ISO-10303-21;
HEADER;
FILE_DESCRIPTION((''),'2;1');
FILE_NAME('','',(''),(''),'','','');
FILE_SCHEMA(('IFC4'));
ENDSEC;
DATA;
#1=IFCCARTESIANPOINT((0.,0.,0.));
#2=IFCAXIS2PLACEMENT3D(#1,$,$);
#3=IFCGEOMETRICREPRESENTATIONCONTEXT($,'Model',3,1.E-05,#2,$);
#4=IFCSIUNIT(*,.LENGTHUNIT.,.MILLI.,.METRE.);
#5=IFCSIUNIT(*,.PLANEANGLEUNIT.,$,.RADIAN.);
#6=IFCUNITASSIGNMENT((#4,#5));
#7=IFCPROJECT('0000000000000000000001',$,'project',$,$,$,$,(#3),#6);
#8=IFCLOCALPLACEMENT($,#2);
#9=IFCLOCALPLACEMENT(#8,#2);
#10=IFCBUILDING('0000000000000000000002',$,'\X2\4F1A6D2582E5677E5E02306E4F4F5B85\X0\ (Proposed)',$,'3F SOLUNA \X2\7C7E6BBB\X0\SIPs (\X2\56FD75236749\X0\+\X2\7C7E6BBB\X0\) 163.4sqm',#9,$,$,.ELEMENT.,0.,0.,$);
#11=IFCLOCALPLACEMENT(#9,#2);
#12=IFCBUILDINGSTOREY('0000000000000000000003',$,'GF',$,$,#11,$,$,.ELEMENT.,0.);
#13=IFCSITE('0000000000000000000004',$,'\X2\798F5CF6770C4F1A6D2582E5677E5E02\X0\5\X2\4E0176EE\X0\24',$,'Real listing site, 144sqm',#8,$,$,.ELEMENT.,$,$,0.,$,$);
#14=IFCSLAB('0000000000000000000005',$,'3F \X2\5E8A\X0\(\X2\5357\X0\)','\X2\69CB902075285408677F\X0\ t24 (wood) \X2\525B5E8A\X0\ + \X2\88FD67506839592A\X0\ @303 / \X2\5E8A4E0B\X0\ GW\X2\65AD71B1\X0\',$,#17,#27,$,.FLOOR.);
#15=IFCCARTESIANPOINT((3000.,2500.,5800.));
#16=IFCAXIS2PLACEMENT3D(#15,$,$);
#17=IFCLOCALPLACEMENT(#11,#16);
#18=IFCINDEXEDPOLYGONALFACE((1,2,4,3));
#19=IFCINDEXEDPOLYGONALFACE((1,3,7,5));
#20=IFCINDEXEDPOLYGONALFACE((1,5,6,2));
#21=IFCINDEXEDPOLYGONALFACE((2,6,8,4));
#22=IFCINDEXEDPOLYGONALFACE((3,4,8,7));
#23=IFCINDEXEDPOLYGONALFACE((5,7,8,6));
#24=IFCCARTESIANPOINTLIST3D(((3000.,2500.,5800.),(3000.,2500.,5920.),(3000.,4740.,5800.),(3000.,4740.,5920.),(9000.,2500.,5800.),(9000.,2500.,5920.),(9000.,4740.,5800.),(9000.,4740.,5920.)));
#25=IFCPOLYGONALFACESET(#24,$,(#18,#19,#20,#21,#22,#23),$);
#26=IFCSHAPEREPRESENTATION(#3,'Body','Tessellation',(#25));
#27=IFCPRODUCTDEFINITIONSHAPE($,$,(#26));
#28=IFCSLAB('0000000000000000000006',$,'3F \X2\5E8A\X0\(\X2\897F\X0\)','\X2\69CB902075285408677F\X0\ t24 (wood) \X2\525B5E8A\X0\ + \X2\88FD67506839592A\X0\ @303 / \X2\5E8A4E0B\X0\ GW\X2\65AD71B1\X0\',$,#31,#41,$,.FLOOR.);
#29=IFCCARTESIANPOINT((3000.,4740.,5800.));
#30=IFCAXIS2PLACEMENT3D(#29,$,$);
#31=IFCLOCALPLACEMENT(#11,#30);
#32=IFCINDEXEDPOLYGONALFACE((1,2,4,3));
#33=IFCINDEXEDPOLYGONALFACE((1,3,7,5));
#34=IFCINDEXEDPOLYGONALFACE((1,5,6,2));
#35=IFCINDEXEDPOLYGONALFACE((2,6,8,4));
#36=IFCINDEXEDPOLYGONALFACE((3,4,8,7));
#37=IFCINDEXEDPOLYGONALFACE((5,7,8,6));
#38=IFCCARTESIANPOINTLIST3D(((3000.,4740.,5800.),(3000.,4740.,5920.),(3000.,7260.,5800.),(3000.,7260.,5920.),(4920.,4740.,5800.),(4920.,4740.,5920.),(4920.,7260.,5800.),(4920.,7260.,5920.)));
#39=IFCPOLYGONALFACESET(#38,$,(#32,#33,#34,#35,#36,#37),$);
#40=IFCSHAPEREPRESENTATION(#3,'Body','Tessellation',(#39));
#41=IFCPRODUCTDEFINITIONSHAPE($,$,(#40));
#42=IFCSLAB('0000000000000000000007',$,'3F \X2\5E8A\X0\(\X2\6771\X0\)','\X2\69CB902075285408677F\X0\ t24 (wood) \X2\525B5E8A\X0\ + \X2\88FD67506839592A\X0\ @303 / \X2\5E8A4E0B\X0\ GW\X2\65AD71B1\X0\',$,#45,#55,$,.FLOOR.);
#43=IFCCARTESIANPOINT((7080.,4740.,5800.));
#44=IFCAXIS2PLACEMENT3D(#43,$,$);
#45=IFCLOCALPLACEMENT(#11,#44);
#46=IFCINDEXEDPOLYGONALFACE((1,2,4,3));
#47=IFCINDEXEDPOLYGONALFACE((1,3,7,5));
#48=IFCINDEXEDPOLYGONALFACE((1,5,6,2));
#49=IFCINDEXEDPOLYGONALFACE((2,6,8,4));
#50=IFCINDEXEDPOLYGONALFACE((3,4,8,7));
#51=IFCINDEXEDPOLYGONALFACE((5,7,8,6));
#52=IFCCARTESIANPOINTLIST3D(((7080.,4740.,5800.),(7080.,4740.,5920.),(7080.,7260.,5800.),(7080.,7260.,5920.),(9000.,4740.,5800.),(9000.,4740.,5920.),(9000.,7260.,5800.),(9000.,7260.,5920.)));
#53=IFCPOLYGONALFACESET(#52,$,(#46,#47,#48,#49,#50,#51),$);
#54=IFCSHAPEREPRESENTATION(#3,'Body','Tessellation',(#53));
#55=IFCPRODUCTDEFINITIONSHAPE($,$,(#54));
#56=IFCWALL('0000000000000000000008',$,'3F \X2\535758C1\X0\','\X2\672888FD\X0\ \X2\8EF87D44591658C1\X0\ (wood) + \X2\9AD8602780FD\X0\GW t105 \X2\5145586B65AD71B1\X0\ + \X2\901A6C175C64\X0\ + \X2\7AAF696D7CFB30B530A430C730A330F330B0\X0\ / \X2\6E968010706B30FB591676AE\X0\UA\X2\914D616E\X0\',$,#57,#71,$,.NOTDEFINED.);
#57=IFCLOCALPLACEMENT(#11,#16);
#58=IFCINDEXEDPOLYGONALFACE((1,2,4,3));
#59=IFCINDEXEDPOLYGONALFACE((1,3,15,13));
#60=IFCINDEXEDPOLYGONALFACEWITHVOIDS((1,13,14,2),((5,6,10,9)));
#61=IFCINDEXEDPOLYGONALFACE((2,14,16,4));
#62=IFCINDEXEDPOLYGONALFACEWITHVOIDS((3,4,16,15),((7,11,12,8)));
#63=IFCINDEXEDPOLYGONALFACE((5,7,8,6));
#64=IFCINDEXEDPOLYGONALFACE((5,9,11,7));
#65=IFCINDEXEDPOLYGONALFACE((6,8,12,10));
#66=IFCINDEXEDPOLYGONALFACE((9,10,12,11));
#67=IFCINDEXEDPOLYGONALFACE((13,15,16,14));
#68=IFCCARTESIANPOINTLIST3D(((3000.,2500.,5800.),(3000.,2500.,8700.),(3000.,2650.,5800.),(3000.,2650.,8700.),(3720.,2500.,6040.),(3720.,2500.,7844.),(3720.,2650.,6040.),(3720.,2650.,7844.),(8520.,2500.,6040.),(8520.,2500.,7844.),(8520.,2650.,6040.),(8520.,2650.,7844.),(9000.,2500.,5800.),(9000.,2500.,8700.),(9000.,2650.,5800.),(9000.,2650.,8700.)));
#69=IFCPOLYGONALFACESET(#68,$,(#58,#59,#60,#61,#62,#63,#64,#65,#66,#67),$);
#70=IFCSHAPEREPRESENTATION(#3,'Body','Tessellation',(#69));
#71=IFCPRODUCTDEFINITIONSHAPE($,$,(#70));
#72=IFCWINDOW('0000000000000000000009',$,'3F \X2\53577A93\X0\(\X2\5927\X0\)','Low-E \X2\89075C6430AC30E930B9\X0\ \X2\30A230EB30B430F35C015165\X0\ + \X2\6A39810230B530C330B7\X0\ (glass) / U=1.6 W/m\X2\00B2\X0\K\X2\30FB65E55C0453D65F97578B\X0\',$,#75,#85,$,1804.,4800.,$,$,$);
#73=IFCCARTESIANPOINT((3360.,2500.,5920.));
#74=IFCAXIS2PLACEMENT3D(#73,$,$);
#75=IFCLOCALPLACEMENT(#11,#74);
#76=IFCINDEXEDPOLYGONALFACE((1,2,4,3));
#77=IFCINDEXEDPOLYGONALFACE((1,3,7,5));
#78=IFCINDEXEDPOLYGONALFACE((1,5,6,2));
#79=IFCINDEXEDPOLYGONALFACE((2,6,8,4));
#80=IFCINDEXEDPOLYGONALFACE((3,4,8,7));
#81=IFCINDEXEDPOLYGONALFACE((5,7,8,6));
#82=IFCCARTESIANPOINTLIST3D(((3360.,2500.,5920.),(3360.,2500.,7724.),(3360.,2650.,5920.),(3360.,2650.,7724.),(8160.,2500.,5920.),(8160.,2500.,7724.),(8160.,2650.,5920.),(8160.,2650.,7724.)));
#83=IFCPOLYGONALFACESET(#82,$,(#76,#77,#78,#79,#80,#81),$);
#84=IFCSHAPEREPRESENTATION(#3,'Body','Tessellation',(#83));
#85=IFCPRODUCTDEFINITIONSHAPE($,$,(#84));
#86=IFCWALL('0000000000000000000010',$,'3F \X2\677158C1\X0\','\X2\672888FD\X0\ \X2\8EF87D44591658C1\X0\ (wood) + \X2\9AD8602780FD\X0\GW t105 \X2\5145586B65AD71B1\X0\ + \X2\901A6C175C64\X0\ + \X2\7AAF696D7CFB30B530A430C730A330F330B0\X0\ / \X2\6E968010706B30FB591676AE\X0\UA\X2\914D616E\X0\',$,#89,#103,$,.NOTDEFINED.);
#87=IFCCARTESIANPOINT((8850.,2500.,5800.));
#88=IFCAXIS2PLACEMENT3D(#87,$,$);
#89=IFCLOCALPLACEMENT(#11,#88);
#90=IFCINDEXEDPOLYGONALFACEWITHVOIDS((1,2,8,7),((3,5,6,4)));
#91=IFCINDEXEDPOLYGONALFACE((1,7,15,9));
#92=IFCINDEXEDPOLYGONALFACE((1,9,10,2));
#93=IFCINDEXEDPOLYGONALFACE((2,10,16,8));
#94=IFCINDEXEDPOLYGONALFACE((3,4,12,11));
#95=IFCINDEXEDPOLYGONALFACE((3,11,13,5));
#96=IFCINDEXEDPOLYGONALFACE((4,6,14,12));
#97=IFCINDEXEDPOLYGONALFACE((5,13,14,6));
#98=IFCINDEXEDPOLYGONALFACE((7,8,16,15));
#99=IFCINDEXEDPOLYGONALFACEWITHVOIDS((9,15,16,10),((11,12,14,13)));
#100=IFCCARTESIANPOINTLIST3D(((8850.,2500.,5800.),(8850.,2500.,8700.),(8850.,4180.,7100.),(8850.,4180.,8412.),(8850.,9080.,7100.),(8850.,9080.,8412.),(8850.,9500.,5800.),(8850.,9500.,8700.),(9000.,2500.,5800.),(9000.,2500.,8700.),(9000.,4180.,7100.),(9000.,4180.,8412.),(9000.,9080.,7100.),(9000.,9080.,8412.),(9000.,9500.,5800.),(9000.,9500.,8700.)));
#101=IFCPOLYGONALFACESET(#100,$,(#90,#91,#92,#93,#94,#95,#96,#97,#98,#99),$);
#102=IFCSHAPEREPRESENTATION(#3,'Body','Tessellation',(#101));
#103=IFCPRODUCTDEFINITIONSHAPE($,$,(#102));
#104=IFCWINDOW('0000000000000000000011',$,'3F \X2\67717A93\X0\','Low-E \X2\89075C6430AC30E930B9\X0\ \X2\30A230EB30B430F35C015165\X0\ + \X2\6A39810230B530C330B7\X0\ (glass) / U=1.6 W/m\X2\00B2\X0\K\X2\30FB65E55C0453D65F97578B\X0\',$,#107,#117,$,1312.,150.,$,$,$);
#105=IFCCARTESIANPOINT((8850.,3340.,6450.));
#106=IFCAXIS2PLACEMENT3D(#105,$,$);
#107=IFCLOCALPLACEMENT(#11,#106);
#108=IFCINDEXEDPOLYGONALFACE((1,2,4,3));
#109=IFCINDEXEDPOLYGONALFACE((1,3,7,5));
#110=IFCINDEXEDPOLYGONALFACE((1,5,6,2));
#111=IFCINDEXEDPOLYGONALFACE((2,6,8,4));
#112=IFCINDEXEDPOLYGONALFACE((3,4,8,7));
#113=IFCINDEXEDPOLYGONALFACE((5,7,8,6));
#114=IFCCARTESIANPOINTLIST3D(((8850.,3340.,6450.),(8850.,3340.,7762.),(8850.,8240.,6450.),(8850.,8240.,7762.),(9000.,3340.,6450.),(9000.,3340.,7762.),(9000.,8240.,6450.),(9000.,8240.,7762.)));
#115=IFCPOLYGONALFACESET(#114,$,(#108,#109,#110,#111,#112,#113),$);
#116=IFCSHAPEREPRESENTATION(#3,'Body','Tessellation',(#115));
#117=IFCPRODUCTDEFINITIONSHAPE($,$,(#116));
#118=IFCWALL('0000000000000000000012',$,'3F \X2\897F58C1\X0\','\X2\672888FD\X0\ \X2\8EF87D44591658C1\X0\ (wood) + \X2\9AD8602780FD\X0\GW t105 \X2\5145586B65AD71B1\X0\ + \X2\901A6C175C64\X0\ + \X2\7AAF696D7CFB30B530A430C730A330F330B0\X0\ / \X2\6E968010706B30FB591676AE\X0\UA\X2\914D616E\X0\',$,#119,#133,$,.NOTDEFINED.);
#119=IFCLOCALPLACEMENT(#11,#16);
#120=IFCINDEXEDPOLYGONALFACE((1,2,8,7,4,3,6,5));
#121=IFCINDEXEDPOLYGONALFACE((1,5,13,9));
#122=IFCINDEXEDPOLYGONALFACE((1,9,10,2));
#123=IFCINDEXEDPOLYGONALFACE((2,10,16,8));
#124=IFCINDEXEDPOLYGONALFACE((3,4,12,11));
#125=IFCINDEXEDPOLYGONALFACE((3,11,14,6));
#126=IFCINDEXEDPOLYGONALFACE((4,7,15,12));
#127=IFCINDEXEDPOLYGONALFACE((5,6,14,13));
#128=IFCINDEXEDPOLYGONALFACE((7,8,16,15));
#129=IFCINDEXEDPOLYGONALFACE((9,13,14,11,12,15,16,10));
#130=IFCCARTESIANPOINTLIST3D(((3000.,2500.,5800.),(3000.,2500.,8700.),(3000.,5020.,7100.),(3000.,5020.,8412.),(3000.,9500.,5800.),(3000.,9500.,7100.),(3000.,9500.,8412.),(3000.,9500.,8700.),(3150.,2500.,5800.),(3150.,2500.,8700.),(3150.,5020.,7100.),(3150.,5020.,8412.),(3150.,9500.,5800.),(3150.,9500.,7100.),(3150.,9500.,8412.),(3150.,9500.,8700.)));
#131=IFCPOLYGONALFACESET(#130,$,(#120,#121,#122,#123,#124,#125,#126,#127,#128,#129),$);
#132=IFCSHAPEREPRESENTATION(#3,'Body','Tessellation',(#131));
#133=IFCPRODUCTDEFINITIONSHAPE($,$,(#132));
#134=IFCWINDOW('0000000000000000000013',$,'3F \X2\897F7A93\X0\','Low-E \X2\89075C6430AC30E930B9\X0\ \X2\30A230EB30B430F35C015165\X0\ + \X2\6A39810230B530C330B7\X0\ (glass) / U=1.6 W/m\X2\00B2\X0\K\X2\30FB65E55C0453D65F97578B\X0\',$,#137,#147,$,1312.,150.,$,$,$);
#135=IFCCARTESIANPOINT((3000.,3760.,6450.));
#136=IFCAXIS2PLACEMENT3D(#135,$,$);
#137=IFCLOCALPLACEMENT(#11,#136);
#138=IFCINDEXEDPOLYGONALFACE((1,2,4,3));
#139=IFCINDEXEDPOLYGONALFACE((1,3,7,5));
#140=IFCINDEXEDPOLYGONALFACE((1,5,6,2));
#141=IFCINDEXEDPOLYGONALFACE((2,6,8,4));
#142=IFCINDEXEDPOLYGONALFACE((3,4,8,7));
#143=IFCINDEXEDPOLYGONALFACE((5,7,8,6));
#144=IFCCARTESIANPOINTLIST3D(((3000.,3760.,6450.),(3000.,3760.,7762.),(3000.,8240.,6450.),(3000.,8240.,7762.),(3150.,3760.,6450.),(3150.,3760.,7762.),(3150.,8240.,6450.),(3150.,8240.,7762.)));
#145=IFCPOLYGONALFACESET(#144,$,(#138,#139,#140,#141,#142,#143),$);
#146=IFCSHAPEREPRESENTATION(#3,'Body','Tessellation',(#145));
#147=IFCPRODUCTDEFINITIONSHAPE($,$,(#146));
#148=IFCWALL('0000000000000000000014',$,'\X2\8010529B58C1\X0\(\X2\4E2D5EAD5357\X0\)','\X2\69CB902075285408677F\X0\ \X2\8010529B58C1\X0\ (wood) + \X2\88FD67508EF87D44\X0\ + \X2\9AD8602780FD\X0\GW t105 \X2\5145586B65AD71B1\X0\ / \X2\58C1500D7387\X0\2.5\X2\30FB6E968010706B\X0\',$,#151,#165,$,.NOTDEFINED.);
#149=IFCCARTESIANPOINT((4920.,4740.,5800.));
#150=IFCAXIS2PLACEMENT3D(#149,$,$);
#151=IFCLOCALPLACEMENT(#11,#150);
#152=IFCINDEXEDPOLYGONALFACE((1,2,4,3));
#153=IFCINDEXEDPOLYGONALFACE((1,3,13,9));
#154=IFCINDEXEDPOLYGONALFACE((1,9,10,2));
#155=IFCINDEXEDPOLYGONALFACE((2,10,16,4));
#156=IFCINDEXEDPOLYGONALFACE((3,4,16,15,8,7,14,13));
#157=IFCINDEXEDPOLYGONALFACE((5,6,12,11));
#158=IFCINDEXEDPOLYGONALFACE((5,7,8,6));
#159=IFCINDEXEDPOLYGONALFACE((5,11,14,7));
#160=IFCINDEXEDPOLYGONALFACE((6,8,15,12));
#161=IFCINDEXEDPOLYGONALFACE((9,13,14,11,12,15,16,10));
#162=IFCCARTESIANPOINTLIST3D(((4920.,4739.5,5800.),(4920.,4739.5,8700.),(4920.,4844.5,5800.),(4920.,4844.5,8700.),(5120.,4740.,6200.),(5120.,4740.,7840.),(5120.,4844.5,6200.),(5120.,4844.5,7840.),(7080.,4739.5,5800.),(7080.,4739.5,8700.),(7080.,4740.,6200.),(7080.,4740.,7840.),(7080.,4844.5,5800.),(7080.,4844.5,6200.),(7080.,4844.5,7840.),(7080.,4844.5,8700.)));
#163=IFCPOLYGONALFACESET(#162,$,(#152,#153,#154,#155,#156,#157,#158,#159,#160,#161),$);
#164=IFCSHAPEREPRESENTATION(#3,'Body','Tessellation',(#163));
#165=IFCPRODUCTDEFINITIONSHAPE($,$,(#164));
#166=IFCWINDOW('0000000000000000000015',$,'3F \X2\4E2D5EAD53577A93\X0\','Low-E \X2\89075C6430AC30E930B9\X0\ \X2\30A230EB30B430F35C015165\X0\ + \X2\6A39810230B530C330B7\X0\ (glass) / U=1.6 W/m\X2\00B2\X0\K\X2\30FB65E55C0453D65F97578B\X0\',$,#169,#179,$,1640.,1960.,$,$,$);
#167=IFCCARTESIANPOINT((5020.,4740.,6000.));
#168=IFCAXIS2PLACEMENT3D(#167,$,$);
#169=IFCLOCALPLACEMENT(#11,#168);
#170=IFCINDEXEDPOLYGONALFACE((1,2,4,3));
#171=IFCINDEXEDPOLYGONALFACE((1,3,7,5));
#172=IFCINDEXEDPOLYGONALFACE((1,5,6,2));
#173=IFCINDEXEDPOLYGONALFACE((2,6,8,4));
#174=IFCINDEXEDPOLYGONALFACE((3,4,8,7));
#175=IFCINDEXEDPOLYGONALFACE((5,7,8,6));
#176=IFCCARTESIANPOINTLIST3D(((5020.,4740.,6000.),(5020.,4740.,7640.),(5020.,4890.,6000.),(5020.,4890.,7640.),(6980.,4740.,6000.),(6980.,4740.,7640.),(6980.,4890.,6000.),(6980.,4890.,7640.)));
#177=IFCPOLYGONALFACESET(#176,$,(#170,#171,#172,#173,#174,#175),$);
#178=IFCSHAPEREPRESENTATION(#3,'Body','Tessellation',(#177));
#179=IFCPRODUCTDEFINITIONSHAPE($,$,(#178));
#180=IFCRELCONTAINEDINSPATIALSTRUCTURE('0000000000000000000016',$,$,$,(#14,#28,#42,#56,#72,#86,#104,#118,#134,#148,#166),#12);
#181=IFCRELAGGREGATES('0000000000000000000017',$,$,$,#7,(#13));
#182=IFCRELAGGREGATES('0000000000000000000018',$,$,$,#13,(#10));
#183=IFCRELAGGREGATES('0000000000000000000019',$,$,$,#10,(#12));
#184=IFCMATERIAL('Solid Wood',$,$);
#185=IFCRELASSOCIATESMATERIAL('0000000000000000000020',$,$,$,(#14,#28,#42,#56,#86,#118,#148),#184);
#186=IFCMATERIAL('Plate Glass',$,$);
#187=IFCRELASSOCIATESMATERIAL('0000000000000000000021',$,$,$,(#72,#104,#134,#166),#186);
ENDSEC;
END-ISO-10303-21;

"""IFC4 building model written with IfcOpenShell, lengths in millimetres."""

from ifc_helpers import new_model, si_unit, frame, frame_2d, origin, place, context, project, spatial, rectangle, extrude, material, element, fill, save


model = new_model("IFC4")

# Units and contexts
model_context = context("Model", 3, precision=1e-05, world=origin())
ifc_project = project(units=[si_unit("LENGTHUNIT", "METRE", prefix="MILLI"), si_unit("PLANEANGLEUNIT", "RADIAN")], contexts=[model_context])

# Site, building, storey
site_placement = place(None, origin())
site = spatial("IfcSite", under=ifc_project, at=site_placement, Name="福島県会津若松市5丁目24", ObjectType="Real listing site, 144sqm", CompositionType="ELEMENT", RefElevation=0.0)
building_placement = place(site_placement, origin())
building = spatial("IfcBuilding", under=site, at=building_placement, Name="会津若松市の住宅 (Proposed)", ObjectType="3F SOLUNA 籾殻SIPs (国産杉+籾殻) 163.4sqm", CompositionType="ELEMENT", ElevationOfRefHeight=0.0, ElevationOfTerrain=0.0)
storey_placement = place(building_placement, origin())
storey = spatial("IfcBuildingStorey", under=building, at=storey_placement, Name="GF", CompositionType="ELEMENT", Elevation=0.0)

# Slabs
ifc_material_1 = material(Name="Solid Wood")
slab_1_placement = place(storey_placement, frame((3000.0, 2500.0, 5800.0)))
element("IfcSlab", 1, at=slab_1_placement, inside=storey, material=ifc_material_1, Name="3F 床(南)", Description="構造用合板 t24 (wood) 剛床 + 製材根太 @303 / 床下 GW断熱", PredefinedType="FLOOR", context=model_context, shape_type="SweptSolid", body=[
    extrude(rectangle(XDim=6000.0, YDim=2240.0, at=frame_2d((3000.0, 1120.0))), frame((3000.0, 2500.0, 5800.0)), (0.0, 0.0, 1.0), 120.0),
])
slab_2_placement = place(storey_placement, frame((3000.0, 4740.0, 5800.0)))
element("IfcSlab", 2, at=slab_2_placement, inside=storey, material=ifc_material_1, Name="3F 床(西)", Description="構造用合板 t24 (wood) 剛床 + 製材根太 @303 / 床下 GW断熱", PredefinedType="FLOOR", context=model_context, shape_type="SweptSolid", body=[
    extrude(rectangle(XDim=1920.0, YDim=2520.0, at=frame_2d((960.0, 1260.0))), frame((3000.0, 4740.0, 5800.0)), (0.0, 0.0, 1.0), 120.0),
])
slab_3_placement = place(storey_placement, frame((7080.0, 4740.0, 5800.0)))
element("IfcSlab", 3, at=slab_3_placement, inside=storey, material=ifc_material_1, Name="3F 床(東)", Description="構造用合板 t24 (wood) 剛床 + 製材根太 @303 / 床下 GW断熱", PredefinedType="FLOOR", context=model_context, shape_type="SweptSolid", body=[
    extrude(rectangle(XDim=1920.0, YDim=2520.0, at=frame_2d((960.0, 1260.0))), frame((7080.0, 4740.0, 5800.0)), (0.0, 0.0, 1.0), 120.0),
])

# Walls, openings, windows
wall_1_placement = place(storey_placement, frame((3000.0, 2500.0, 5800.0)))
wall_1 = element("IfcWall", 4, at=wall_1_placement, inside=storey, material=ifc_material_1, Name="3F 南壁", Description="木製 軸組外壁 (wood) + 高性能GW t105 充填断熱 + 通気層 + 窯業系サイディング / 準耐火・外皮UA配慮", PredefinedType="NOTDEFINED", context=model_context, shape_type="SweptSolid", body=[
    extrude(rectangle(XDim=6000.0, YDim=150.0, at=frame_2d((3000.0, 75.0))), frame((3000.0, 2500.0, 5800.0)), (0.0, 0.0, 1.0), 2900.0),
])
opening_1_placement = place(storey_placement, frame((3360.0, 2500.0, 5920.0)))
opening_1 = element("IfcOpeningElement", 5, at=opening_1_placement, cuts=wall_1, PredefinedType="NOTDEFINED", context=model_context, shape_type="SweptSolid", body=[
    extrude(rectangle(XDim=4800.0, YDim=150.0, at=frame_2d((2400.0, 75.0))), frame((3360.0, 2500.0, 5920.0)), (0.0, 0.0, 1.0), 1804.0),
])
ifc_material_2 = material(Name="Plate Glass")
window_1_placement = place(storey_placement, frame((3360.0, 2500.0, 5920.0)))
window_1 = element("IfcWindow", 6, at=window_1_placement, inside=storey, material=ifc_material_2, Name="3F 南窓(大)", Description="Low-E 複層ガラス アルゴン封入 + 樹脂サッシ (glass) / U=1.6 W/m²K・日射取得型", OverallHeight=1804.0, OverallWidth=4800.0, context=model_context, shape_type="SweptSolid", body=[
    extrude(rectangle(XDim=4800.0, YDim=150.0, at=frame_2d((2400.0, 75.0))), frame((3360.0, 2500.0, 5920.0)), (0.0, 0.0, 1.0), 1804.0),
])
fill(opening_1, window_1)
wall_2_placement = place(storey_placement, frame((8850.0, 2500.0, 5800.0)))
wall_2 = element("IfcWall", 7, at=wall_2_placement, inside=storey, material=ifc_material_1, Name="3F 東壁", Description="木製 軸組外壁 (wood) + 高性能GW t105 充填断熱 + 通気層 + 窯業系サイディング / 準耐火・外皮UA配慮", PredefinedType="NOTDEFINED", context=model_context, shape_type="SweptSolid", body=[
    extrude(rectangle(XDim=150.0, YDim=7000.0, at=frame_2d((75.0, 3500.0))), frame((8850.0, 2500.0, 5800.0)), (0.0, 0.0, 1.0), 2900.0),
])
opening_2_placement = place(storey_placement, frame((8850.0, 3340.0, 6450.0)))
opening_2 = element("IfcOpeningElement", 8, at=opening_2_placement, cuts=wall_2, PredefinedType="NOTDEFINED", context=model_context, shape_type="SweptSolid", body=[
    extrude(rectangle(XDim=150.0, YDim=4900.0, at=frame_2d((75.0, 2450.0))), frame((8850.0, 3340.0, 6450.0)), (0.0, 0.0, 1.0), 1312.0),
])
window_2_placement = place(storey_placement, frame((8850.0, 3340.0, 6450.0)))
window_2 = element("IfcWindow", 9, at=window_2_placement, inside=storey, material=ifc_material_2, Name="3F 東窓", Description="Low-E 複層ガラス アルゴン封入 + 樹脂サッシ (glass) / U=1.6 W/m²K・日射取得型", OverallHeight=1312.0, OverallWidth=150.0, context=model_context, shape_type="SweptSolid", body=[
    extrude(rectangle(XDim=150.0, YDim=4900.0, at=frame_2d((75.0, 2450.0))), frame((8850.0, 3340.0, 6450.0)), (0.0, 0.0, 1.0), 1312.0),
])
fill(opening_2, window_2)
wall_3_placement = place(storey_placement, frame((3000.0, 2500.0, 5800.0)))
wall_3 = element("IfcWall", 10, at=wall_3_placement, inside=storey, material=ifc_material_1, Name="3F 西壁", Description="木製 軸組外壁 (wood) + 高性能GW t105 充填断熱 + 通気層 + 窯業系サイディング / 準耐火・外皮UA配慮", PredefinedType="NOTDEFINED", context=model_context, shape_type="SweptSolid", body=[
    extrude(rectangle(XDim=150.0, YDim=7000.0, at=frame_2d((75.0, 3500.0))), frame((3000.0, 2500.0, 5800.0)), (0.0, 0.0, 1.0), 2900.0),
])
opening_3_placement = place(storey_placement, frame((3000.0, 3760.0, 6450.0)))
opening_3 = element("IfcOpeningElement", 11, at=opening_3_placement, cuts=wall_3, PredefinedType="NOTDEFINED", context=model_context, shape_type="SweptSolid", body=[
    extrude(rectangle(XDim=150.0, YDim=4480.0, at=frame_2d((75.0, 2240.0))), frame((3000.0, 3760.0, 6450.0)), (0.0, 0.0, 1.0), 1312.0),
])
window_3_placement = place(storey_placement, frame((3000.0, 3760.0, 6450.0)))
window_3 = element("IfcWindow", 12, at=window_3_placement, inside=storey, material=ifc_material_2, Name="3F 西窓", Description="Low-E 複層ガラス アルゴン封入 + 樹脂サッシ (glass) / U=1.6 W/m²K・日射取得型", OverallHeight=1312.0, OverallWidth=150.0, context=model_context, shape_type="SweptSolid", body=[
    extrude(rectangle(XDim=150.0, YDim=4480.0, at=frame_2d((75.0, 2240.0))), frame((3000.0, 3760.0, 6450.0)), (0.0, 0.0, 1.0), 1312.0),
])
fill(opening_3, window_3)
wall_4_placement = place(storey_placement, frame((4920.0, 4740.0, 5800.0)))
wall_4 = element("IfcWall", 13, at=wall_4_placement, inside=storey, material=ifc_material_1, Name="耐力壁(中庭南)", Description="構造用合板 耐力壁 (wood) + 製材軸組 + 高性能GW t105 充填断熱 / 壁倍率2.5・準耐火", PredefinedType="NOTDEFINED", context=model_context, shape_type="SweptSolid", body=[
    extrude(rectangle(XDim=2160.0, YDim=105.0, at=frame_2d((1080.0, 52.0))), frame((4920.0, 4740.0, 5800.0)), (0.0, 0.0, 1.0), 2900.0),
])
opening_4_placement = place(storey_placement, frame((5020.0, 4740.0, 6000.0)))
opening_4 = element("IfcOpeningElement", 14, at=opening_4_placement, cuts=wall_4, PredefinedType="NOTDEFINED", context=model_context, shape_type="SweptSolid", body=[
    extrude(rectangle(XDim=1960.0, YDim=150.0, at=frame_2d((980.0, 75.0))), frame((5020.0, 4740.0, 6000.0)), (0.0, 0.0, 1.0), 1640.0),
])
window_4_placement = place(storey_placement, frame((5020.0, 4740.0, 6000.0)))
window_4 = element("IfcWindow", 15, at=window_4_placement, inside=storey, material=ifc_material_2, Name="3F 中庭南窓", Description="Low-E 複層ガラス アルゴン封入 + 樹脂サッシ (glass) / U=1.6 W/m²K・日射取得型", OverallHeight=1640.0, OverallWidth=1960.0, context=model_context, shape_type="SweptSolid", body=[
    extrude(rectangle(XDim=1960.0, YDim=150.0, at=frame_2d((980.0, 75.0))), frame((5020.0, 4740.0, 6000.0)), (0.0, 0.0, 1.0), 1640.0),
])
fill(opening_4, window_4)

save(model, "model.ifc")
